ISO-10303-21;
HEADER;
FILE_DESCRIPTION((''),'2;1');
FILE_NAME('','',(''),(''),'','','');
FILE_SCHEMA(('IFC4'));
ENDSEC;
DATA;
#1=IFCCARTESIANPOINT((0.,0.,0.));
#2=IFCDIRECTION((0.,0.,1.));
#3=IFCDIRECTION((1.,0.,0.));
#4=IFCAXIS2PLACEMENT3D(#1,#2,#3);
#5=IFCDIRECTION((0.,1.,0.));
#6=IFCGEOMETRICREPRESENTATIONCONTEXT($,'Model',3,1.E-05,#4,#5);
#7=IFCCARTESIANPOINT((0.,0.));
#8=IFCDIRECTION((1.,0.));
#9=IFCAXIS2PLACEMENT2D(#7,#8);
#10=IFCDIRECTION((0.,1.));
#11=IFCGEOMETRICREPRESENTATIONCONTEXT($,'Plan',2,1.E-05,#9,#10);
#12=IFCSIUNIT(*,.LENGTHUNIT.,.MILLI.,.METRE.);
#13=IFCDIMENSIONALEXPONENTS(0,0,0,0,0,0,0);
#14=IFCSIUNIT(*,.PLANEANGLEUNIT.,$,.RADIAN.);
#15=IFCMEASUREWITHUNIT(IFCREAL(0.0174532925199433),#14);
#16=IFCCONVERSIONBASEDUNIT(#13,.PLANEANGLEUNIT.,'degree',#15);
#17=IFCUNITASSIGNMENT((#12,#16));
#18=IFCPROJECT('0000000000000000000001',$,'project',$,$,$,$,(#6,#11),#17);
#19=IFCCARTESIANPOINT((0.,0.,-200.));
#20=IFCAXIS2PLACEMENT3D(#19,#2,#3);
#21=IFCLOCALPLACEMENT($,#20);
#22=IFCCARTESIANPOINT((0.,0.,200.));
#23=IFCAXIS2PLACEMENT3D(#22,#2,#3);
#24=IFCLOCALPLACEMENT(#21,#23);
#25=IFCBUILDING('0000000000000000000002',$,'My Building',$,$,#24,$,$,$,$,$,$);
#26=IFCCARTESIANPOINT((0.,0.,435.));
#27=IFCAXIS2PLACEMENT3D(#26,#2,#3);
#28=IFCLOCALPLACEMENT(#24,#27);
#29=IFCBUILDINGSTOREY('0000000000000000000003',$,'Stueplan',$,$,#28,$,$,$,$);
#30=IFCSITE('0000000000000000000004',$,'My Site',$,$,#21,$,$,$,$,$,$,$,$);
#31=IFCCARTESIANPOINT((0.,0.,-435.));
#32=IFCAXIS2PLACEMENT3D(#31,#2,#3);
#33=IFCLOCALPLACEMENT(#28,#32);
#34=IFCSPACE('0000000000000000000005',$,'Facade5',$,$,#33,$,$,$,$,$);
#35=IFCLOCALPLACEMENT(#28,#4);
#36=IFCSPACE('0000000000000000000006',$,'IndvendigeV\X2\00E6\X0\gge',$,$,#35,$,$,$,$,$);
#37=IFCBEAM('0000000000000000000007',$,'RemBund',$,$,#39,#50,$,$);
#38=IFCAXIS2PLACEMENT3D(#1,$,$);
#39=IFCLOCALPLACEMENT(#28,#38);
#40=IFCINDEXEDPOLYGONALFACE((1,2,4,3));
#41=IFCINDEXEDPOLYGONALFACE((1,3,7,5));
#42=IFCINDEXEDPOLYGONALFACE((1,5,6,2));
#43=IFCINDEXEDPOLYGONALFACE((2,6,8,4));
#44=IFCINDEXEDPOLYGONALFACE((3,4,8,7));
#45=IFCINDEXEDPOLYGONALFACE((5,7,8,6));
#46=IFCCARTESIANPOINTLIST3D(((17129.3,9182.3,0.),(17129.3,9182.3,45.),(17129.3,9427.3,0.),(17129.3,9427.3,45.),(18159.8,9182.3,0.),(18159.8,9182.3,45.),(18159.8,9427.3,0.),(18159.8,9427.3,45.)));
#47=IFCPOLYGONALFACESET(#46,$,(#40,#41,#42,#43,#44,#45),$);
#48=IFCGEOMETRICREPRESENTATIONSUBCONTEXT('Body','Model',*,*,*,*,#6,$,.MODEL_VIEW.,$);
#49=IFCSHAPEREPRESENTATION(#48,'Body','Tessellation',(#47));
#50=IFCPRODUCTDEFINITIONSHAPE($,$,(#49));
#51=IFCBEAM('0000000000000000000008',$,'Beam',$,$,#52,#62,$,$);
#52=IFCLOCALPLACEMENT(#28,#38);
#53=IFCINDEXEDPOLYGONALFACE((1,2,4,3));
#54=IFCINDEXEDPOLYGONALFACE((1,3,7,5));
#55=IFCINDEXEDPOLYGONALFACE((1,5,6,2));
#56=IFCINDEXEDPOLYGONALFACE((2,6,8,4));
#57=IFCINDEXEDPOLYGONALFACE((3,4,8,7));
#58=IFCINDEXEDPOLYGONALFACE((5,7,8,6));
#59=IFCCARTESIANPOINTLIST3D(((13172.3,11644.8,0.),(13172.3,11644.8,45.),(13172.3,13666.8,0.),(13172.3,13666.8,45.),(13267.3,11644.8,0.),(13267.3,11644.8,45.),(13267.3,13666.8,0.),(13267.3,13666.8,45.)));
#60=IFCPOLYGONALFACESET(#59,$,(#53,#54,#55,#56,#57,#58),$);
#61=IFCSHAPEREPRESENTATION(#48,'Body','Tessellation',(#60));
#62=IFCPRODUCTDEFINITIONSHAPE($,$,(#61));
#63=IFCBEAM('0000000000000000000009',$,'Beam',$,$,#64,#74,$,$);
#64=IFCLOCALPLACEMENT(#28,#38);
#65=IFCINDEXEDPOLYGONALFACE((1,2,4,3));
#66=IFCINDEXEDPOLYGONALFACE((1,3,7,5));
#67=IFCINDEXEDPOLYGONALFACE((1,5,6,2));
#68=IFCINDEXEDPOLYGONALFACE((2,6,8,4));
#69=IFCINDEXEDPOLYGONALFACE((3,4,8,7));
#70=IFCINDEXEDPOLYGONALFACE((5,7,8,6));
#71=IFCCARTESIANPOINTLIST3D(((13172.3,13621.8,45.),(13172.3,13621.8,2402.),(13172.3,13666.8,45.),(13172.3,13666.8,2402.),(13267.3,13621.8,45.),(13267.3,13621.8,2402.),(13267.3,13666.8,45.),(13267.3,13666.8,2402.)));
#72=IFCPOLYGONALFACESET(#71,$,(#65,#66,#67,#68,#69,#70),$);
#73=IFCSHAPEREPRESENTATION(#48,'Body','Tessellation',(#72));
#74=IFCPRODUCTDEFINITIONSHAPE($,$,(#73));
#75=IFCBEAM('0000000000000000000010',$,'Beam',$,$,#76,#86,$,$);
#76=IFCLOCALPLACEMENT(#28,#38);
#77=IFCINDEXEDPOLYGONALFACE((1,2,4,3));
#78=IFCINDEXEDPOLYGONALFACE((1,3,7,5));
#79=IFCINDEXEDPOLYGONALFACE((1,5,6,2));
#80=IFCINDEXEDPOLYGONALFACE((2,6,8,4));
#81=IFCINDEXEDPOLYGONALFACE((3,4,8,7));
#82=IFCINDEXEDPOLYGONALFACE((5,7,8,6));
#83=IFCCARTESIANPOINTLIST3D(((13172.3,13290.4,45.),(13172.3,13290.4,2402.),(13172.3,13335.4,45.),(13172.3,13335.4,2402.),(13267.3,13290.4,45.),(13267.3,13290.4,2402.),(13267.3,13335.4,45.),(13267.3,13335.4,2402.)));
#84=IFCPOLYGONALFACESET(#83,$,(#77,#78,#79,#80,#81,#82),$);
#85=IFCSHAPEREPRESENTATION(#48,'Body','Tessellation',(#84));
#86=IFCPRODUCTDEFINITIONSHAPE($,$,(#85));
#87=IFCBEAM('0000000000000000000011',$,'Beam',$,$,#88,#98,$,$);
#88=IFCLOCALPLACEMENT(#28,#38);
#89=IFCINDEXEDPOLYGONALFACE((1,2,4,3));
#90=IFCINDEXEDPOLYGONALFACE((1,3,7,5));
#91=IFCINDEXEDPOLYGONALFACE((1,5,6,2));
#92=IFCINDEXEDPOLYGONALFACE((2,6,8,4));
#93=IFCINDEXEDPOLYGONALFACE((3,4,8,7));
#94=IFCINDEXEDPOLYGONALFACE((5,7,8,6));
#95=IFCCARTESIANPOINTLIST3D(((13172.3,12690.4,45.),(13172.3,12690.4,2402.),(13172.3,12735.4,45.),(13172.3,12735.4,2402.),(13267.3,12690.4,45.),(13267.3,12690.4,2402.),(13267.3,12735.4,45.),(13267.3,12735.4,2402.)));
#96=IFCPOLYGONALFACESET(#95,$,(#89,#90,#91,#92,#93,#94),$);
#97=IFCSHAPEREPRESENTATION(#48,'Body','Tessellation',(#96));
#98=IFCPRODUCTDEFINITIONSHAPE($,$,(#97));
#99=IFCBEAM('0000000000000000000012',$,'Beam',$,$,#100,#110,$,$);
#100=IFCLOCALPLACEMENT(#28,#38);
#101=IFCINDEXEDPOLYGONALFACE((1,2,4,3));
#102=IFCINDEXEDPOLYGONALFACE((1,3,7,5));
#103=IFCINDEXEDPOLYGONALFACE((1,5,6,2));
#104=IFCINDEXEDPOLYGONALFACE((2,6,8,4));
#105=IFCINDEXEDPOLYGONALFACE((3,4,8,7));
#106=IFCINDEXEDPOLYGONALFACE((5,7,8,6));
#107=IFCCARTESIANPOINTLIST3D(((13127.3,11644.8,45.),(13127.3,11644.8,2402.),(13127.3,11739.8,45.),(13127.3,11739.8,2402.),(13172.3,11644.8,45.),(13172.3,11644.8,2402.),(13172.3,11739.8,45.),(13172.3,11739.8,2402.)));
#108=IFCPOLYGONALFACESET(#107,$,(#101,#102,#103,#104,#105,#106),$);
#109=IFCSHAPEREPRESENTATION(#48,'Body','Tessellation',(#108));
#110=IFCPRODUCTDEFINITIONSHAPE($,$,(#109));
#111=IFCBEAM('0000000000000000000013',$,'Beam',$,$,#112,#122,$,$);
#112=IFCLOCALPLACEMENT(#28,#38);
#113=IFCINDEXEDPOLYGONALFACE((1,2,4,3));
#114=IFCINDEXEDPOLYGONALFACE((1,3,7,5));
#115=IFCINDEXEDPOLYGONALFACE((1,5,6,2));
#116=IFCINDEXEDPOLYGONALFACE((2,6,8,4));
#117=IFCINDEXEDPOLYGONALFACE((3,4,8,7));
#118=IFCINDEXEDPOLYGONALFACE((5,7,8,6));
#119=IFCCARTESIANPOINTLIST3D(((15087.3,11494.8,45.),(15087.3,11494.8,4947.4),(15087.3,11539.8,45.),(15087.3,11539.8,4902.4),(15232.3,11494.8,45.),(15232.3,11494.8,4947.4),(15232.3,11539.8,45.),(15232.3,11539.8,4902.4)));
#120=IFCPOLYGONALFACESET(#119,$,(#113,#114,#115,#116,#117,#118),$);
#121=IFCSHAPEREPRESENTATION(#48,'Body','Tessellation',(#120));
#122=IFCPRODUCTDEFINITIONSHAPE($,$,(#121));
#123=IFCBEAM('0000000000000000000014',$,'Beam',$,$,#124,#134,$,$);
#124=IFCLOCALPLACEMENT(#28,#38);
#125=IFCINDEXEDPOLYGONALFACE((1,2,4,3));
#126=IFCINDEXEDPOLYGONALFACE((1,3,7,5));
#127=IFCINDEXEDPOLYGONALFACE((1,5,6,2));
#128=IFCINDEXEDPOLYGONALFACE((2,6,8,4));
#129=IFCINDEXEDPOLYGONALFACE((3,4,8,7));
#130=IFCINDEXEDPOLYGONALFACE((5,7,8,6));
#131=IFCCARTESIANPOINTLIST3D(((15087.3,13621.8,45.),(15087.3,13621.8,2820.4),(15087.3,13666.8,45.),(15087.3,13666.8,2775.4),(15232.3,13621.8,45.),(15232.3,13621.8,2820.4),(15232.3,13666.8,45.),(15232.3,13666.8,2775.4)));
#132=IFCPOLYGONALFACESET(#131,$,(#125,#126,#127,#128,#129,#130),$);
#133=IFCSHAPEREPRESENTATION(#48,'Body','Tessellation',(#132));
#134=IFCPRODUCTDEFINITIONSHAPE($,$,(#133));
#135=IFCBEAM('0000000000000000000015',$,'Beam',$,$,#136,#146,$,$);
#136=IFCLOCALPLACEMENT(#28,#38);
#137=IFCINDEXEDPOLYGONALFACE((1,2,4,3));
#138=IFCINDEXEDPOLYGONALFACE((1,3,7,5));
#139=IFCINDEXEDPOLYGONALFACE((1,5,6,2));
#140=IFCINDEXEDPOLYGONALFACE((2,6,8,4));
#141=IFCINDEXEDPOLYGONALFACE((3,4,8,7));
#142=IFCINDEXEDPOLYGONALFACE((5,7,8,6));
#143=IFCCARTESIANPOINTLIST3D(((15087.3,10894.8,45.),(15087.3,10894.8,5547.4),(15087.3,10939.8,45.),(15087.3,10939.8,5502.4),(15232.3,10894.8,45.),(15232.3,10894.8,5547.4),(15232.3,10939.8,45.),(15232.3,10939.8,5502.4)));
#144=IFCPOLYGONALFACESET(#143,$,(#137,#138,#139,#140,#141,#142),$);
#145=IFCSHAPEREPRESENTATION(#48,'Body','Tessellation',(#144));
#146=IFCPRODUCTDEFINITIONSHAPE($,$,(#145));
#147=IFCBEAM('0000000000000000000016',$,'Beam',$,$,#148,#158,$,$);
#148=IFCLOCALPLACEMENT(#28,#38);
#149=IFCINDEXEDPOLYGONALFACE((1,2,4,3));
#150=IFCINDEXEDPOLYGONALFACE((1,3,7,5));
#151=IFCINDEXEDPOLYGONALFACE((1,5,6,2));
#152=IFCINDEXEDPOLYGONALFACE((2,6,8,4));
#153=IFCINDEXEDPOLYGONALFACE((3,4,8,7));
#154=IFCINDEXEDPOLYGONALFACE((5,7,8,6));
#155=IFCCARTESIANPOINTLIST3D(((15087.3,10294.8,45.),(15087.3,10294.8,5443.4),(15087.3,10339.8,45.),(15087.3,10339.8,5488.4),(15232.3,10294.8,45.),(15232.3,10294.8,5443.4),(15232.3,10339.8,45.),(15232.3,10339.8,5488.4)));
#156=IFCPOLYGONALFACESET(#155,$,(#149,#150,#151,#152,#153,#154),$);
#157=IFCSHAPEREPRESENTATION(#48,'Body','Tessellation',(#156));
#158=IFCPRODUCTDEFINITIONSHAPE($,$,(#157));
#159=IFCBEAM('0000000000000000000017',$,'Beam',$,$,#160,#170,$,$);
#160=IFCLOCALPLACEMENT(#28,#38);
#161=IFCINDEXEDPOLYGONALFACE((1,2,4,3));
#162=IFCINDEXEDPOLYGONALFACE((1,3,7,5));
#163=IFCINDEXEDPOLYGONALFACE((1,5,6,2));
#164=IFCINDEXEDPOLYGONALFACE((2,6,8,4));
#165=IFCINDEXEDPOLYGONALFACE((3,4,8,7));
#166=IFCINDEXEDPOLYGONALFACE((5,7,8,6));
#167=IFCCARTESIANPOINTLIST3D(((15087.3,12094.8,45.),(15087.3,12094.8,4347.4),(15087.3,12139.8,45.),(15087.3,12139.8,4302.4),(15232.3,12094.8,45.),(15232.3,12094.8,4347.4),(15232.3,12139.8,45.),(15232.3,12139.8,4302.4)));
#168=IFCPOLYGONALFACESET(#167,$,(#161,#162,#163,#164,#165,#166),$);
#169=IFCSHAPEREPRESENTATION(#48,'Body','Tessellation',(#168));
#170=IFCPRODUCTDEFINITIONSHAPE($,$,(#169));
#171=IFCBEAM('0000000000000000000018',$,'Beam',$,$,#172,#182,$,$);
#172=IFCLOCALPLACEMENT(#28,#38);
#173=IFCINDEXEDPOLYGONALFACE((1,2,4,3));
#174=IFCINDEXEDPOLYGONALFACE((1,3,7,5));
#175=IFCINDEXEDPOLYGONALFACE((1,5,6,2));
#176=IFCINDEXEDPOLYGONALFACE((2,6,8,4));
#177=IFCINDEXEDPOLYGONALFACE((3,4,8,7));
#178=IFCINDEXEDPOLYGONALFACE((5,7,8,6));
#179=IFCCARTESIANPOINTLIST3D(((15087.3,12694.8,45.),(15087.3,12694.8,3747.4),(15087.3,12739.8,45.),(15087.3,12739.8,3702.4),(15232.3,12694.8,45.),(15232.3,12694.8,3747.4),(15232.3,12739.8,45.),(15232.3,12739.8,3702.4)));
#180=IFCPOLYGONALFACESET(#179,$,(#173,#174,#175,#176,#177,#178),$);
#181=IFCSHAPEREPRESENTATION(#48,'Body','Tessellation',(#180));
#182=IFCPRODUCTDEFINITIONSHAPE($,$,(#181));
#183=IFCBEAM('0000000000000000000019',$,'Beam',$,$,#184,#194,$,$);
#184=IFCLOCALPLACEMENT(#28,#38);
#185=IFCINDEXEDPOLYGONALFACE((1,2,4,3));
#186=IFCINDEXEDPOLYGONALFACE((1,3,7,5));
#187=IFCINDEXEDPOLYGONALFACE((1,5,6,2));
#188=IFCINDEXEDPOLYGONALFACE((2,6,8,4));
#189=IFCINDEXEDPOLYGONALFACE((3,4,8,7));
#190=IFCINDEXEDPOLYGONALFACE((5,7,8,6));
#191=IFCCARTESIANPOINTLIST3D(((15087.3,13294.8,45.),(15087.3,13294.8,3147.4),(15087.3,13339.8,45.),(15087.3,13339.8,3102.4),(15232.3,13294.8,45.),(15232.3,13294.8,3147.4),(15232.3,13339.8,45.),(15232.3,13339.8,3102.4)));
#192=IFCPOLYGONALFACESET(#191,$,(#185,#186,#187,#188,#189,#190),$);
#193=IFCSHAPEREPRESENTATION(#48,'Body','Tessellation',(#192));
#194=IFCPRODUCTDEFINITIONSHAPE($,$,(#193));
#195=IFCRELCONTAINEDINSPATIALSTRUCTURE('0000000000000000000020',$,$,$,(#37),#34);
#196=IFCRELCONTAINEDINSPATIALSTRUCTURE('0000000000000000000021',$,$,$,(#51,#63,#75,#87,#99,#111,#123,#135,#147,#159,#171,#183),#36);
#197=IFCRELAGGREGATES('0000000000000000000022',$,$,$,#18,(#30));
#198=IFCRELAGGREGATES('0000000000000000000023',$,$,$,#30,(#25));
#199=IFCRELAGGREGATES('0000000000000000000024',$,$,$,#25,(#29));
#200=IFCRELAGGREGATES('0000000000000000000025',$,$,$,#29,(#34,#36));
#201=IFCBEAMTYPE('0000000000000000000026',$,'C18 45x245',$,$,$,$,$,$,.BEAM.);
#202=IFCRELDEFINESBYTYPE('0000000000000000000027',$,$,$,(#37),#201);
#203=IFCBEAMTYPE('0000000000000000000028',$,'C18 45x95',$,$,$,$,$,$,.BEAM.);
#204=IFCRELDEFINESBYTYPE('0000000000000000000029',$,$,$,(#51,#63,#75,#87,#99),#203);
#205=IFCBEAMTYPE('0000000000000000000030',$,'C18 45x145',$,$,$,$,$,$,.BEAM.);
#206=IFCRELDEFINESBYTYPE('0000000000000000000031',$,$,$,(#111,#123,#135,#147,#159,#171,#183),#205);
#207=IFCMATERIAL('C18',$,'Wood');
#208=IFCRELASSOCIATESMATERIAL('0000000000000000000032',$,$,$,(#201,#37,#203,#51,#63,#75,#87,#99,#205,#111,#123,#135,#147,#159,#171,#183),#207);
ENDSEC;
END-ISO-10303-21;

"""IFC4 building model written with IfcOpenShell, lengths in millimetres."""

from ifc_helpers import new_model, entity, si_unit, converted_unit, direction, frame, origin_with_axes, origin_2d_with_axis, place, context, subcontext, project, spatial, rectangle, extrude, clip, halfspace, material, material_profile, profile_set, profile_usage, type_object, element, save


model = new_model("IFC4")

# Units and contexts
model_context = context("Model", 3, precision=1e-05, world=origin_with_axes(), true_north=direction((0.0, 1.0, 0.0)))
plan_context = context("Plan", 2, precision=1e-05, world=origin_2d_with_axis(), true_north=direction((0.0, 1.0)))
body_context_1 = subcontext(model_context, "Body", "Model", "MODEL_VIEW")
ifc_project = project(units=[si_unit("LENGTHUNIT", "METRE", prefix="MILLI"), converted_unit("PLANEANGLEUNIT", "degree", entity("IfcReal", 0.0174532925199433), si_unit("PLANEANGLEUNIT", "RADIAN"), dimensions=[0, 0, 0, 0, 0, 0, 0])], contexts=[model_context, plan_context])

# Site, building, storey
site_placement = place(None, frame((0.0, 0.0, -200.0), z_axis=(0.0, 0.0, 1.0), x_axis=(1.0, 0.0, 0.0)))
site = spatial("IfcSite", under=ifc_project, at=site_placement, Name="My Site")
building_placement = place(site_placement, frame((0.0, 0.0, 200.0), z_axis=(0.0, 0.0, 1.0), x_axis=(1.0, 0.0, 0.0)))
building = spatial("IfcBuilding", under=site, at=building_placement, Name="My Building")
storey_placement = place(building_placement, frame((0.0, 0.0, 435.0), z_axis=(0.0, 0.0, 1.0), x_axis=(1.0, 0.0, 0.0)))
storey = spatial("IfcBuildingStorey", under=building, at=storey_placement, Name="Stueplan")

# Shared definitions
ifc_material = material(Name="C18", Category="Wood")

# Shared definitions
space_1_placement = place(storey_placement, frame((0.0, 0.0, -435.0), z_axis=(0.0, 0.0, 1.0), x_axis=(1.0, 0.0, 0.0)))
space_1 = spatial("IfcSpace", under=storey, at=space_1_placement, Name="Facade5")

# Beam
ifc_material_profile_1 = material_profile(ifc_material, rectangle(XDim=45.0, YDim=245.0), Name="concrete")
ifc_profile_set_1 = profile_set([ifc_material_profile_1], Name="woodStructural")
beam_type_1 = type_object("IfcBeamType", Name="C18 45x245", PredefinedType="BEAM", material=ifc_profile_set_1)
ifc_profile_usage_1 = profile_usage(ifc_profile_set_1)
beam_1_placement = place(space_1_placement, frame((17129.3, 9304.8, 457.5), z_axis=(1.0, 0.0, 0.0), x_axis=(0.0, 0.0, 1.0)))
element("IfcBeam", 1, at=beam_1_placement, inside=space_1, type_object=beam_type_1, material=ifc_profile_usage_1, Name="RemBund", context=body_context_1, shape_type="SweptSolid", body=[
    extrude(rectangle(XDim=45.0, YDim=245.0), origin_with_axes(), (0.0, 0.0, 1.0), 1030.5),
])

# Shared definitions
space_2_placement = place(storey_placement, frame((0.0, 0.0, 0.0), z_axis=(0.0, 0.0, 1.0), x_axis=(1.0, 0.0, 0.0)))
space_2 = spatial("IfcSpace", under=storey, at=space_2_placement, Name="IndvendigeVægge")

# Beams
ifc_material_profile_2 = material_profile(ifc_material, rectangle(XDim=45.0, YDim=95.0))
ifc_profile_set_2 = profile_set([ifc_material_profile_2], Name="woodStructural")
ifc_profile_usage_2 = profile_usage(ifc_profile_set_2, cardinal=5)
beam_type_2 = type_object("IfcBeamType", Name="C18 45x95", PredefinedType="BEAM", material=ifc_profile_set_2)
beam_2_placement = place(space_2_placement, frame((13219.8, 11644.8, 22.5), z_axis=(0.0, 1.0, 0.0), x_axis=(0.0, 0.0, 1.0)))
element("IfcBeam", 2, at=beam_2_placement, inside=space_2, type_object=beam_type_2, material=ifc_profile_usage_2, Name="Beam", context=body_context_1, shape_type="SweptSolid", body=[
    extrude(rectangle(XDim=45.0, YDim=95.0), origin_with_axes(), (0.0, 0.0, 1.0), 2022.0),
])
ifc_profile_usage_3 = profile_usage(ifc_profile_set_2)
beam_3_placement = place(space_2_placement, frame((13219.8, 13644.3, 45.0), z_axis=(0.0, 0.0, 1.0), x_axis=(0.0, -1.0, 0.0)))
element("IfcBeam", 3, at=beam_3_placement, inside=space_2, type_object=beam_type_2, material=ifc_profile_usage_3, Name="Beam", context=body_context_1, shape_type="SweptSolid", body=[
    extrude(rectangle(XDim=45.0, YDim=95.0), origin_with_axes(), (0.0, 0.0, 1.0), 2357.0),
])
ifc_profile_usage_4 = profile_usage(ifc_profile_set_2)
beam_4_placement = place(space_2_placement, frame((13219.8, 13312.9, 45.0), z_axis=(0.0, 0.0, 1.0), x_axis=(0.0, -1.0, 0.0)))
element("IfcBeam", 4, at=beam_4_placement, inside=space_2, type_object=beam_type_2, material=ifc_profile_usage_4, Name="Beam", context=body_context_1, shape_type="SweptSolid", body=[
    extrude(rectangle(XDim=45.0, YDim=95.0), origin_with_axes(), (0.0, 0.0, 1.0), 2357.0),
])
ifc_profile_usage_5 = profile_usage(ifc_profile_set_2)
beam_5_placement = place(space_2_placement, frame((13219.8, 12712.9, 45.0), z_axis=(0.0, 0.0, 1.0), x_axis=(0.0, -1.0, 0.0)))
element("IfcBeam", 5, at=beam_5_placement, inside=space_2, type_object=beam_type_2, material=ifc_profile_usage_5, Name="Beam", context=body_context_1, shape_type="SweptSolid", body=[
    extrude(rectangle(XDim=45.0, YDim=95.0), origin_with_axes(), (0.0, 0.0, 1.0), 2357.0),
])
ifc_profile_usage_6 = profile_usage(ifc_profile_set_2)
beam_6_placement = place(space_2_placement, frame((13149.8, 11692.3, 45.0), z_axis=(0.0, 0.0, 1.0), x_axis=(1.0, 0.0, 0.0)))
element("IfcBeam", 6, at=beam_6_placement, inside=space_2, type_object=beam_type_2, material=ifc_profile_usage_6, Name="Beam", context=body_context_1, shape_type="SweptSolid", body=[
    extrude(rectangle(XDim=45.0, YDim=95.0), origin_with_axes(), (0.0, 0.0, 1.0), 2357.0),
])
ifc_material_profile_3 = material_profile(ifc_material, rectangle(XDim=45.0, YDim=145.0))
ifc_profile_set_3 = profile_set([ifc_material_profile_3], Name="woodStructural")
ifc_profile_usage_7 = profile_usage(ifc_profile_set_3)
beam_type_3 = type_object("IfcBeamType", Name="C18 45x145", PredefinedType="BEAM", material=ifc_profile_set_3)
beam_7_placement = place(space_2_placement, frame((15159.8, 11517.3, 45.0), z_axis=(0.0, 0.0, 1.0), x_axis=(0.0, -1.0, 0.0)))
element("IfcBeam", 7, at=beam_7_placement, inside=space_2, type_object=beam_type_3, material=ifc_profile_usage_7, Name="Beam", context=body_context_1, shape_type="Clipping", body=[
    clip(extrude(rectangle(XDim=45.0, YDim=145.0), origin_with_axes(), (0.0, 0.0, 1.0), 5024.9), halfspace(frame((-2236.1, 0.0, 2643.8), z_axis=(-0.707107, 0.0, 0.707107), x_axis=(0.000001, 1.0, 0.0)), False)),
])
ifc_profile_usage_8 = profile_usage(ifc_profile_set_3)
beam_8_placement = place(space_2_placement, frame((15159.8, 13644.3, 45.0), z_axis=(0.0, 0.0, 1.0), x_axis=(0.0, -1.0, 0.0)))
element("IfcBeam", 8, at=beam_8_placement, inside=space_2, type_object=beam_type_3, material=ifc_profile_usage_8, Name="Beam", context=body_context_1, shape_type="Clipping", body=[
    clip(extrude(rectangle(XDim=45.0, YDim=145.0), origin_with_axes(), (0.0, 0.0, 1.0), 2897.9), halfspace(frame((-109.1, 0.0, 2643.8), z_axis=(-0.707107, 0.0, 0.707107), x_axis=(0.000001, 1.0, 0.0)), False)),
])
ifc_profile_usage_9 = profile_usage(ifc_profile_set_3)
beam_9_placement = place(space_2_placement, frame((15159.8, 10917.3, 45.0), z_axis=(0.0, 0.0, 1.0), x_axis=(0.0, -1.0, 0.0)))
element("IfcBeam", 9, at=beam_9_placement, inside=space_2, type_object=beam_type_3, material=ifc_profile_usage_9, Name="Beam", context=body_context_1, shape_type="Clipping", body=[
    clip(extrude(rectangle(XDim=45.0, YDim=145.0), origin_with_axes(), (0.0, 0.0, 1.0), 5624.9), halfspace(frame((-2836.1, 0.0, 2643.8), z_axis=(-0.707107, 0.0, 0.707107), x_axis=(0.000001, 1.0, 0.0)), False)),
])
ifc_profile_usage_10 = profile_usage(ifc_profile_set_3)
beam_10_placement = place(space_2_placement, frame((15159.8, 10317.3, 45.0), z_axis=(0.0, 0.0, 1.0), x_axis=(0.0, -1.0, 0.0)))
element("IfcBeam", 10, at=beam_10_placement, inside=space_2, type_object=beam_type_3, material=ifc_profile_usage_10, Name="Beam", context=body_context_1, shape_type="Clipping", body=[
    clip(extrude(rectangle(XDim=45.0, YDim=145.0), origin_with_axes(), (0.0, 0.0, 1.0), 5565.9), halfspace(frame((1209.1, 0.0, 4211.8), z_axis=(0.707107, 0.0, 0.707107), x_axis=(0.0, -1.0, 0.0)), False)),
])
ifc_profile_usage_11 = profile_usage(ifc_profile_set_3)
beam_11_placement = place(space_2_placement, frame((15159.8, 12117.3, 45.0), z_axis=(0.0, 0.0, 1.0), x_axis=(0.0, -1.0, 0.0)))
element("IfcBeam", 11, at=beam_11_placement, inside=space_2, type_object=beam_type_3, material=ifc_profile_usage_11, Name="Beam", context=body_context_1, shape_type="Clipping", body=[
    clip(extrude(rectangle(XDim=45.0, YDim=145.0), origin_with_axes(), (0.0, 0.0, 1.0), 4424.9), halfspace(frame((-1636.1, 0.0, 2643.8), z_axis=(-0.707107, 0.0, 0.707107), x_axis=(0.000001, 1.0, 0.0)), False)),
])
ifc_profile_usage_12 = profile_usage(ifc_profile_set_3)
beam_12_placement = place(space_2_placement, frame((15159.8, 12717.3, 45.0), z_axis=(0.0, 0.0, 1.0), x_axis=(0.0, -1.0, 0.0)))
element("IfcBeam", 12, at=beam_12_placement, inside=space_2, type_object=beam_type_3, material=ifc_profile_usage_12, Name="Beam", context=body_context_1, shape_type="Clipping", body=[
    clip(extrude(rectangle(XDim=45.0, YDim=145.0), origin_with_axes(), (0.0, 0.0, 1.0), 3824.9), halfspace(frame((-1036.1, 0.0, 2643.8), z_axis=(-0.707107, 0.0, 0.707107), x_axis=(0.000001, 1.0, 0.0)), False)),
])
ifc_profile_usage_13 = profile_usage(ifc_profile_set_3)
beam_13_placement = place(space_2_placement, frame((15159.8, 13317.3, 45.0), z_axis=(0.0, 0.0, 1.0), x_axis=(0.0, -1.0, 0.0)))
element("IfcBeam", 13, at=beam_13_placement, inside=space_2, type_object=beam_type_3, material=ifc_profile_usage_13, Name="Beam", context=body_context_1, shape_type="Clipping", body=[
    clip(extrude(rectangle(XDim=45.0, YDim=145.0), origin_with_axes(), (0.0, 0.0, 1.0), 3224.9), halfspace(frame((-436.1, 0.0, 2643.8), z_axis=(-0.707107, 0.0, 0.707107), x_axis=(0.000001, 1.0, 0.0)), False)),
])

save(model, "model.ifc")
